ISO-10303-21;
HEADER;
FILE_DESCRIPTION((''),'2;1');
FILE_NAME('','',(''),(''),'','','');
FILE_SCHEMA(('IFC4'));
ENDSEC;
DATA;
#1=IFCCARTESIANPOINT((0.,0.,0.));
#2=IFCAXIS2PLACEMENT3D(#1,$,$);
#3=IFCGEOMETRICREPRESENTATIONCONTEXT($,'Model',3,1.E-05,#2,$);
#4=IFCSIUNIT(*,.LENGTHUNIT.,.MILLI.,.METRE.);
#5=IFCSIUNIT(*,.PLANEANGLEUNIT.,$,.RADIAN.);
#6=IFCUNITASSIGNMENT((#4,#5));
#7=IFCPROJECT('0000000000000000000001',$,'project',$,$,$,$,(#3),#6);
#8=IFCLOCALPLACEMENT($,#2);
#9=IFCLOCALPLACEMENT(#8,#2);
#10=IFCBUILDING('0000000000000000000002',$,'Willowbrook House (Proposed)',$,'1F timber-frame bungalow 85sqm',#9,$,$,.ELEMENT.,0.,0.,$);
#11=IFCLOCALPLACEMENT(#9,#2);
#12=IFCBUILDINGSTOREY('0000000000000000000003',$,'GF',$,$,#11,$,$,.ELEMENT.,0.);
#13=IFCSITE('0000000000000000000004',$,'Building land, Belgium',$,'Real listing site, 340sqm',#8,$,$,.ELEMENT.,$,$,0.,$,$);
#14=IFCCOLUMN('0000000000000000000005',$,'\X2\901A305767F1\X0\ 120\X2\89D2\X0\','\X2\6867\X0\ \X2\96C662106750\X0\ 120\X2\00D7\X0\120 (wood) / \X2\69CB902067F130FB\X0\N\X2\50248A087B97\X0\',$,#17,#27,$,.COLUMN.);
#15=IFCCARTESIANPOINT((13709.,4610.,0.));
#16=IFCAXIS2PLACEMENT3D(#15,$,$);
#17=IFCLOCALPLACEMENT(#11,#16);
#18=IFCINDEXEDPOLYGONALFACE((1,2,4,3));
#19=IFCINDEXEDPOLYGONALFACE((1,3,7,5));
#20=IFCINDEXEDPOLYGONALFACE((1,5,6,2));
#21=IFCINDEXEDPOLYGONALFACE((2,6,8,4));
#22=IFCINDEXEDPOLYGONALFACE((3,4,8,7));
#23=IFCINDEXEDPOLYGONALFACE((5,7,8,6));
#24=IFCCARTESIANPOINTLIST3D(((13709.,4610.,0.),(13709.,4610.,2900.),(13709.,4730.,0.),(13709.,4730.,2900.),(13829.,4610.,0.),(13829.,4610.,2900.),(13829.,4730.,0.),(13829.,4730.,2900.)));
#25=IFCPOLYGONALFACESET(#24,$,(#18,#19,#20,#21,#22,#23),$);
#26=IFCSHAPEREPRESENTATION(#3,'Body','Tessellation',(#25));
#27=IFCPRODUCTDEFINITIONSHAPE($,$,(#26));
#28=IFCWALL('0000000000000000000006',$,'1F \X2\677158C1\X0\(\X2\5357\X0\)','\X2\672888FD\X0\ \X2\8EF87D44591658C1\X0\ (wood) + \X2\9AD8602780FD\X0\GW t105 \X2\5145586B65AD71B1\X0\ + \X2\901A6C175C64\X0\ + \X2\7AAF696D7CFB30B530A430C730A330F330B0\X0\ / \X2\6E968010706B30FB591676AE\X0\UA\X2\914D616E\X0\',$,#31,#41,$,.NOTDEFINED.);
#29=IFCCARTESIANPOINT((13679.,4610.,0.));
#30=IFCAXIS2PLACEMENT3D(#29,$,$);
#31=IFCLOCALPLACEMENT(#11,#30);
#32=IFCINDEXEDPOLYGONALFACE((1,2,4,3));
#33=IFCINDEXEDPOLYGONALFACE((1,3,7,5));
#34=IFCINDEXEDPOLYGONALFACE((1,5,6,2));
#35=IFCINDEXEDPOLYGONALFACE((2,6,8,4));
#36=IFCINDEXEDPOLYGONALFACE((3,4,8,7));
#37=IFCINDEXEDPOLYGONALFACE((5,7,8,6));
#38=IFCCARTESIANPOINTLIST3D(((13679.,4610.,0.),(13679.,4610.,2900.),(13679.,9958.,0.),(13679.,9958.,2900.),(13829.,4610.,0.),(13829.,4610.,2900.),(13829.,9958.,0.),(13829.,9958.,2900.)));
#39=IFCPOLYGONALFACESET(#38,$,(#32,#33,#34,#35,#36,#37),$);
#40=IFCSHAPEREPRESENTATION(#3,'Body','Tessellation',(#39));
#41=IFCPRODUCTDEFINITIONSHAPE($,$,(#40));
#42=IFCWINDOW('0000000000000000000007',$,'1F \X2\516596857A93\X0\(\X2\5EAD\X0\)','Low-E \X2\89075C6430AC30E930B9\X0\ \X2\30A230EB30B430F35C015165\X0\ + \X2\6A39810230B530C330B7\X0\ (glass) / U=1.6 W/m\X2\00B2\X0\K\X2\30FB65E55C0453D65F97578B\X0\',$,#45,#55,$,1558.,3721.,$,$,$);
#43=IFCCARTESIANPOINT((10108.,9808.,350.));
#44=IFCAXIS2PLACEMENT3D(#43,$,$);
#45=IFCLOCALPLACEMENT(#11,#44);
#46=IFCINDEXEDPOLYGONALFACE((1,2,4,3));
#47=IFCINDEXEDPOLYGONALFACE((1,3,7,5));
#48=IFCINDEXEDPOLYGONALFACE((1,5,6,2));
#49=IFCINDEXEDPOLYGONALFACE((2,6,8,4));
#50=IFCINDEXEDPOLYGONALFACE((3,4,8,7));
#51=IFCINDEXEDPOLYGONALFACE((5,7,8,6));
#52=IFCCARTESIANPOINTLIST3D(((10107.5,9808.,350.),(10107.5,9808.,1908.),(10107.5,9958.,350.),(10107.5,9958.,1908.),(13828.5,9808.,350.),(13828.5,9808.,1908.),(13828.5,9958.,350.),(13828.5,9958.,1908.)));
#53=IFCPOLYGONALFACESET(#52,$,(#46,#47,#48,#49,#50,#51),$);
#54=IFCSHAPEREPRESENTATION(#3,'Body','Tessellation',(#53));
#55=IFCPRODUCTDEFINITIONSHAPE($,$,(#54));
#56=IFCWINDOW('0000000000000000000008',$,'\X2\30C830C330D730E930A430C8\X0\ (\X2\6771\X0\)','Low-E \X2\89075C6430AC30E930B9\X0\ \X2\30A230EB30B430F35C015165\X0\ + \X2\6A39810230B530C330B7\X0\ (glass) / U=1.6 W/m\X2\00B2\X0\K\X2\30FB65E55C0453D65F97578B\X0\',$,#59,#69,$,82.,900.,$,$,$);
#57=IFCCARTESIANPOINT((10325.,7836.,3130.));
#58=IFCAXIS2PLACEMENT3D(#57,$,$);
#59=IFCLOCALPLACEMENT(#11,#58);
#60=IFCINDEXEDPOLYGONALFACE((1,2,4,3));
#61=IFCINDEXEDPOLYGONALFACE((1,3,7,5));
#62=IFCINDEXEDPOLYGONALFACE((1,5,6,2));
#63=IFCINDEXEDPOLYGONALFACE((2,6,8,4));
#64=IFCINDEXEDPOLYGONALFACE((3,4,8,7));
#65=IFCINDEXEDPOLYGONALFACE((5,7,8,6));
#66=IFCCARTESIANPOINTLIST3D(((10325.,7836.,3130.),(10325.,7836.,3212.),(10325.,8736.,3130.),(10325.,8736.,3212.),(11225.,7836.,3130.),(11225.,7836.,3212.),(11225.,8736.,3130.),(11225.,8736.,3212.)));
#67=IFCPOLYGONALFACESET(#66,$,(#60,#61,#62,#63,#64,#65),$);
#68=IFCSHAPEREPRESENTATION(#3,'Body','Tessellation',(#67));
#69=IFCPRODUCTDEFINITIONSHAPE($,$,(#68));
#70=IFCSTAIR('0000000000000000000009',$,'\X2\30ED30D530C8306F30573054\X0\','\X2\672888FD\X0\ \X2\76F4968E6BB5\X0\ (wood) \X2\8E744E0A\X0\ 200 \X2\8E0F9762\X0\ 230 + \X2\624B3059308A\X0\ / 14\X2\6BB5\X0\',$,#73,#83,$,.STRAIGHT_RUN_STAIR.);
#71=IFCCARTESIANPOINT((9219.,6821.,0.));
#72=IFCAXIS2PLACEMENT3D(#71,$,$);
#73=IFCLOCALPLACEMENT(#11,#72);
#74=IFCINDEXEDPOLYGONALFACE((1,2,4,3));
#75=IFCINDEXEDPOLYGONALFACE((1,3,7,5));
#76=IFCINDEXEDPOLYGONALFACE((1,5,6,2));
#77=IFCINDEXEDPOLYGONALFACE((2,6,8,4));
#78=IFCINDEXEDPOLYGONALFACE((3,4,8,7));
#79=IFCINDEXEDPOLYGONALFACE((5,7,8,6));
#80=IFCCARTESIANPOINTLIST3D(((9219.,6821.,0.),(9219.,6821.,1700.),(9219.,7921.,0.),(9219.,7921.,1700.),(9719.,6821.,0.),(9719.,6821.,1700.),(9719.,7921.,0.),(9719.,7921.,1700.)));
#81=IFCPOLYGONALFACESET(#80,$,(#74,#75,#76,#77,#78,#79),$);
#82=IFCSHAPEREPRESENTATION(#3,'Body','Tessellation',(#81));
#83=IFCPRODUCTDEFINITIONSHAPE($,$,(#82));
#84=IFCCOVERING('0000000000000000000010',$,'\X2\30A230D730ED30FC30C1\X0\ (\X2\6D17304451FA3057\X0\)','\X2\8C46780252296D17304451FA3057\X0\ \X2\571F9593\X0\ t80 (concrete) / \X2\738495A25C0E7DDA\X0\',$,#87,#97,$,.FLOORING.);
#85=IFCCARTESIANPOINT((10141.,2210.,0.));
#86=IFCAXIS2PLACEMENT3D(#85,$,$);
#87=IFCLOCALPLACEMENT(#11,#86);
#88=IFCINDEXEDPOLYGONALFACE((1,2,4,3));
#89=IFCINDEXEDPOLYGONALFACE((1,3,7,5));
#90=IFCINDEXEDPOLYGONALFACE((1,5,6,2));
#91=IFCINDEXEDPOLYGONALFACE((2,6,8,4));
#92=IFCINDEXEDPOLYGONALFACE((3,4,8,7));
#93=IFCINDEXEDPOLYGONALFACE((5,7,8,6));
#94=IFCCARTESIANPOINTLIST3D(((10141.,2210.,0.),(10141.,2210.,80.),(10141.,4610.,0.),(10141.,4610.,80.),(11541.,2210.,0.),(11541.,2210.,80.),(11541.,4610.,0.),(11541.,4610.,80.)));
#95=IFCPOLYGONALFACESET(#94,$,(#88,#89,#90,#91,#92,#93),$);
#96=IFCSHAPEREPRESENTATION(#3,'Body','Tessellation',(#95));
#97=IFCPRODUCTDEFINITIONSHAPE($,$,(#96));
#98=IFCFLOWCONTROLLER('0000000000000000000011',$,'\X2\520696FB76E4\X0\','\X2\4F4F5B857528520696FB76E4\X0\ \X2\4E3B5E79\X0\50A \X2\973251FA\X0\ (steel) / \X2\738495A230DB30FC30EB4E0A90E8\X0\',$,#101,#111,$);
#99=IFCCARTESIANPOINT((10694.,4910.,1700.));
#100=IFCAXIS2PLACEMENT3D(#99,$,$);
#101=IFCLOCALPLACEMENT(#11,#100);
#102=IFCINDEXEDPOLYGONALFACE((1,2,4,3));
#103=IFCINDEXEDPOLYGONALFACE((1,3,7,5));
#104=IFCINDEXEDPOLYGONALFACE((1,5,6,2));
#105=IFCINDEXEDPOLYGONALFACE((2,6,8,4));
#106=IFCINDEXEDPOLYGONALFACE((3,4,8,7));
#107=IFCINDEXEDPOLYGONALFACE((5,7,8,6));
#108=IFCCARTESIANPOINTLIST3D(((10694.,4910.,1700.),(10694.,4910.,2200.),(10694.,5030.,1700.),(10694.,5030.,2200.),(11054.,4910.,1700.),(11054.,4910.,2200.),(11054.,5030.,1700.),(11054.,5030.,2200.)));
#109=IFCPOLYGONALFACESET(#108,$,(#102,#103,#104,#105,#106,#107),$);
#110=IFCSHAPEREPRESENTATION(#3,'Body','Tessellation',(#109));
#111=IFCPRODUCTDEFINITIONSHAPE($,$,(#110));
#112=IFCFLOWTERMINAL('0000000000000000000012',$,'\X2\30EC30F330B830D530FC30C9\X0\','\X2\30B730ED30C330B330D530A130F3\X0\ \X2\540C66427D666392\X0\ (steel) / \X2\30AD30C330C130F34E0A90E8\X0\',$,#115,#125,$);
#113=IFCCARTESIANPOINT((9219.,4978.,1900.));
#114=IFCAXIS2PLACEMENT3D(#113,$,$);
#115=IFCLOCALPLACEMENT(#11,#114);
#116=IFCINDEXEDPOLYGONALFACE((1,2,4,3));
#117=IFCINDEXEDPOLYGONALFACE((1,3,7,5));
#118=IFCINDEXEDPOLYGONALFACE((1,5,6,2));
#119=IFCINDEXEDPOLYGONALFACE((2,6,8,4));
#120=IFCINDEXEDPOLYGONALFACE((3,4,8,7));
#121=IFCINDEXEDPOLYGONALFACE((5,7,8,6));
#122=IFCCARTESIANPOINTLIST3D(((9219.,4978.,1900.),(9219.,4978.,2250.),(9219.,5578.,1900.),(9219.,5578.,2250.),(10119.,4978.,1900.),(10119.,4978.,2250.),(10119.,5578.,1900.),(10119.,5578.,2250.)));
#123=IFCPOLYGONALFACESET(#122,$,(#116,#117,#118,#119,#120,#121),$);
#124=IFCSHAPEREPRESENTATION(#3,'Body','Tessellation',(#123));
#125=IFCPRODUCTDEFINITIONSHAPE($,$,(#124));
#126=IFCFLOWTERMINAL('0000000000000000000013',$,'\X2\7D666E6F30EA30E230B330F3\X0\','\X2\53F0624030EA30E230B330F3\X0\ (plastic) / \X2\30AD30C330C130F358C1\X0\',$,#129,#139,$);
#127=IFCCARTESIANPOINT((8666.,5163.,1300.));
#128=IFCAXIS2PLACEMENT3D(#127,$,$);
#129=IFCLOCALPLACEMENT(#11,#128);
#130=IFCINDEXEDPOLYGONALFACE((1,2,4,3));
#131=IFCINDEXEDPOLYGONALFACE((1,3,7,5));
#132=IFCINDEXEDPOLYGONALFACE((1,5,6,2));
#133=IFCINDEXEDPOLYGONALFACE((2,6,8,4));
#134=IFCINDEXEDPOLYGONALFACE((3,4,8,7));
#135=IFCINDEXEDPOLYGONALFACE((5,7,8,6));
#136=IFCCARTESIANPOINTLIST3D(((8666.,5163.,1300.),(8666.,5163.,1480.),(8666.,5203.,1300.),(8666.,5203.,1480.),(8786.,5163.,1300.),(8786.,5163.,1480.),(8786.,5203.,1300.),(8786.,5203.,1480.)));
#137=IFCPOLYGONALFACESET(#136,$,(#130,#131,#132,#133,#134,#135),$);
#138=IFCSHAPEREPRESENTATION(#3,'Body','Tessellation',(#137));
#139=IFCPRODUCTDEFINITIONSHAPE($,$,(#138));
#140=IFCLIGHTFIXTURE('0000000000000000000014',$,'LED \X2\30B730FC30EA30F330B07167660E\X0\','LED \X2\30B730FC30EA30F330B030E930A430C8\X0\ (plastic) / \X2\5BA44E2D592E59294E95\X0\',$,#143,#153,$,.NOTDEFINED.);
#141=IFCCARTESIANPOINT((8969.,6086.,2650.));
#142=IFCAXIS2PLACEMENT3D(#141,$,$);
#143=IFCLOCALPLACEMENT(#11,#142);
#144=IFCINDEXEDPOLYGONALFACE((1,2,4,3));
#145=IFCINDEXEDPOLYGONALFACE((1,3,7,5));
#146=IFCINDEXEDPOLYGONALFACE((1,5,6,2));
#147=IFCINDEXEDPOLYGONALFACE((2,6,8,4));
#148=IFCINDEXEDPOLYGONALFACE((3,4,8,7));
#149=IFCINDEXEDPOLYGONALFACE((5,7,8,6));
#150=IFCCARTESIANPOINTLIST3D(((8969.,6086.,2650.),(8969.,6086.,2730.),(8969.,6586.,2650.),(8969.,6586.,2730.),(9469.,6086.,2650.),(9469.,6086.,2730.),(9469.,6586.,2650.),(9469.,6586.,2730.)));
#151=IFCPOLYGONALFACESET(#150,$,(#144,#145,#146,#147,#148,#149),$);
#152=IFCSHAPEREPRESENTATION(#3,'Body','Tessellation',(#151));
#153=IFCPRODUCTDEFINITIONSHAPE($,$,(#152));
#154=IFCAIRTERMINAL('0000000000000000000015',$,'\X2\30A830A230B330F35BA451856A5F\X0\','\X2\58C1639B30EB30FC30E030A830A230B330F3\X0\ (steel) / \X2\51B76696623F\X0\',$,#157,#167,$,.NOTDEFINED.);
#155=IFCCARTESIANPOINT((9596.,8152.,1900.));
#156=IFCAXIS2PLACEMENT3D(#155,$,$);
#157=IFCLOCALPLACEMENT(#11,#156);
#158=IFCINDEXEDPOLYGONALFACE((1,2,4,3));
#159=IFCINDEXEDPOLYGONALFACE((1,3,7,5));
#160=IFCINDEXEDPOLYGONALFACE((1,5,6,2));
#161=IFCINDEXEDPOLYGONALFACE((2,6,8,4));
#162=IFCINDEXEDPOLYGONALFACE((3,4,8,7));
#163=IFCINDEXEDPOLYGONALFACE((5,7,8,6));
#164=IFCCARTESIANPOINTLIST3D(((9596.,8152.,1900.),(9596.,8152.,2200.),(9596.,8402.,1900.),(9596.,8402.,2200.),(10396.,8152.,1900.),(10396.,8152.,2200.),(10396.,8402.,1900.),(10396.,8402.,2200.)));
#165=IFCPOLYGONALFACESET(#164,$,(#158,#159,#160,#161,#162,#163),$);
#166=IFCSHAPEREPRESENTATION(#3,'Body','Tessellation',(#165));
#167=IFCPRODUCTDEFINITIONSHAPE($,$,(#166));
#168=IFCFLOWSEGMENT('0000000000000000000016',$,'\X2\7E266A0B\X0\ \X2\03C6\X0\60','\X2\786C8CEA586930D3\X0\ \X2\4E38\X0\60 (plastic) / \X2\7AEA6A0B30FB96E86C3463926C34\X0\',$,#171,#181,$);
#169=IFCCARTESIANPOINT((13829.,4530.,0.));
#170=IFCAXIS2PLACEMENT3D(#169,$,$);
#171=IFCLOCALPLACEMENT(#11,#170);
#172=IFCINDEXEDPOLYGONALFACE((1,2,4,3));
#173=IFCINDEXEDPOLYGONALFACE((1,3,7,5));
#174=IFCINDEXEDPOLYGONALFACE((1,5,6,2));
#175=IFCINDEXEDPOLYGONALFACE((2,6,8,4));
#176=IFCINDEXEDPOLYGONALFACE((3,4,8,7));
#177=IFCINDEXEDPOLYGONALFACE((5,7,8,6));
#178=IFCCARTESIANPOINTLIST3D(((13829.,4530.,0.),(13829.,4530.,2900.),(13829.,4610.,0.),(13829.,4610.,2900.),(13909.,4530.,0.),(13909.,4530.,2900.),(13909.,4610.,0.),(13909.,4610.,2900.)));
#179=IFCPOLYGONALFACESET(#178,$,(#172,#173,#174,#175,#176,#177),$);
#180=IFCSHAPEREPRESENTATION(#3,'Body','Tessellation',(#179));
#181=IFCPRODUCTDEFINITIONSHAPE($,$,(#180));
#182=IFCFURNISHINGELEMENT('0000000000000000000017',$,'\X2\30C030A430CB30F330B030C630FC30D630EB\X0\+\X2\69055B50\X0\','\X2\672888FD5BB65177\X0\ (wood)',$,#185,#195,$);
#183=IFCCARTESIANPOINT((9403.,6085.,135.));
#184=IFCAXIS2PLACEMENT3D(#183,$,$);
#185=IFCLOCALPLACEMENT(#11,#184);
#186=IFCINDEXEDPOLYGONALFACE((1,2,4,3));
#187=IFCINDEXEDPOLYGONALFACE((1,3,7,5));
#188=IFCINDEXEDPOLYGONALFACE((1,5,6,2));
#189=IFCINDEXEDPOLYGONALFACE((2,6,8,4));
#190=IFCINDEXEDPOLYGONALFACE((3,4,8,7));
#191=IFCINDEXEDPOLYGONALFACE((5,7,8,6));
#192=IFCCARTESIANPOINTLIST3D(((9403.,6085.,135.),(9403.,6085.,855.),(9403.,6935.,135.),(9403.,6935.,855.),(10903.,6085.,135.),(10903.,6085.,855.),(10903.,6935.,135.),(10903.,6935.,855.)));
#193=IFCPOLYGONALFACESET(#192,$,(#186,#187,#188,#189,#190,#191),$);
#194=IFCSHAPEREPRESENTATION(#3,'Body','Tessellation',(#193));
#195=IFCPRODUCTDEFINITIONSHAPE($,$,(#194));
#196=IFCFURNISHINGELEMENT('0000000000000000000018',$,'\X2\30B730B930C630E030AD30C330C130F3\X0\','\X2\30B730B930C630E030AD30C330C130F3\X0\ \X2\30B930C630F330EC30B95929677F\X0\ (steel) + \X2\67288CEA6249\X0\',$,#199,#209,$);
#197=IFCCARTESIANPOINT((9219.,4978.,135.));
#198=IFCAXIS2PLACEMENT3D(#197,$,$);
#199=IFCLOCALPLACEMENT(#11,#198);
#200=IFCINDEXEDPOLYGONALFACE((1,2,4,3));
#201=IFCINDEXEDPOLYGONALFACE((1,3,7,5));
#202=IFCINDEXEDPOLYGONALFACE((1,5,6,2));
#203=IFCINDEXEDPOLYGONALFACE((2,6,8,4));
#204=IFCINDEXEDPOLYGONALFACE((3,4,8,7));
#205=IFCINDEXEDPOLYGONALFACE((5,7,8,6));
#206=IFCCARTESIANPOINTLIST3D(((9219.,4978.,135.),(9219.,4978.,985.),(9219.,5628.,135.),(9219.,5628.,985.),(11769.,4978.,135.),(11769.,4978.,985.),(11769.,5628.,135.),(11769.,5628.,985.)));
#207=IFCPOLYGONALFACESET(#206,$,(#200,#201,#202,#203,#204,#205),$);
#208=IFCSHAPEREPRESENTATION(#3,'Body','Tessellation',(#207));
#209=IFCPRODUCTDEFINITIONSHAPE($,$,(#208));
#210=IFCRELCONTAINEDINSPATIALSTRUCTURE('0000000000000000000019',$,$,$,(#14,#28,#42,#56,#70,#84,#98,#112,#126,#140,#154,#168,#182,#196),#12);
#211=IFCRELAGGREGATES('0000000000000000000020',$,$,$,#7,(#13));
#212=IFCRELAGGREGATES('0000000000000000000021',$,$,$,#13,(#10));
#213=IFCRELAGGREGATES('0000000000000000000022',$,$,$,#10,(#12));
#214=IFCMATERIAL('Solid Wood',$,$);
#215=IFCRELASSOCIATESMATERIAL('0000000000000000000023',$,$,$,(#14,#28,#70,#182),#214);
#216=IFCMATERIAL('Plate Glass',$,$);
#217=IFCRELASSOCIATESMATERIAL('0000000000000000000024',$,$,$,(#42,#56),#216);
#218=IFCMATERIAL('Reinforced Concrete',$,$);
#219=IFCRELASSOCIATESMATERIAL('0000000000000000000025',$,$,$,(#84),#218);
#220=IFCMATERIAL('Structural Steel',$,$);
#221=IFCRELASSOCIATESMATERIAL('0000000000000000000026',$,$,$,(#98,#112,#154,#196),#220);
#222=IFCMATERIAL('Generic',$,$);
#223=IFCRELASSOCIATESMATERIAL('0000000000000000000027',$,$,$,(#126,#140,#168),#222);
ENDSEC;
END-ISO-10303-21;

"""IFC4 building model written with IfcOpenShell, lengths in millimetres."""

from ifc_helpers import new_model, si_unit, frame, frame_2d, origin, place, context, project, spatial, rectangle, extrude, material, element, fill, save


model = new_model("IFC4")

# Units and contexts
model_context = context("Model", 3, precision=1e-05, world=origin())
ifc_project = project(units=[si_unit("LENGTHUNIT", "METRE", prefix="MILLI"), si_unit("PLANEANGLEUNIT", "RADIAN")], contexts=[model_context])

# Site, building, storey
site_placement = place(None, origin())
site = spatial("IfcSite", under=ifc_project, at=site_placement, Name="Building land, Belgium", ObjectType="Real listing site, 340sqm", CompositionType="ELEMENT", RefElevation=0.0)
building_placement = place(site_placement, origin())
building = spatial("IfcBuilding", under=site, at=building_placement, Name="Willowbrook House (Proposed)", ObjectType="1F timber-frame bungalow 85sqm", CompositionType="ELEMENT", ElevationOfRefHeight=0.0, ElevationOfTerrain=0.0)
storey_placement = place(building_placement, origin())
storey = spatial("IfcBuildingStorey", under=building, at=storey_placement, Name="GF", CompositionType="ELEMENT", Elevation=0.0)

# Column
ifc_material_1 = material(Name="Solid Wood")
column_1_placement = place(storey_placement, frame((13709.0, 4610.0, 0.0)))
element("IfcColumn", 1, at=column_1_placement, inside=storey, material=ifc_material_1, Name="通し柱 120角", Description="桧 集成材 120×120 (wood) / 構造柱・N値計算", PredefinedType="COLUMN", context=model_context, shape_type="SweptSolid", body=[
    extrude(rectangle(XDim=120.0, YDim=120.0, at=frame_2d((60.0, 60.0))), frame((13709.0, 4610.0, 0.0)), (0.0, 0.0, 1.0), 2900.0),
])

# Wall, opening, window
wall_1_placement = place(storey_placement, frame((13679.0, 4610.0, 0.0)))
wall_1 = element("IfcWall", 2, at=wall_1_placement, inside=storey, material=ifc_material_1, Name="1F 東壁(南)", Description="木製 軸組外壁 (wood) + 高性能GW t105 充填断熱 + 通気層 + 窯業系サイディング / 準耐火・外皮UA配慮", PredefinedType="NOTDEFINED", context=model_context, shape_type="SweptSolid", body=[
    extrude(rectangle(XDim=150.0, YDim=5348.0, at=frame_2d((75.0, 2674.0))), frame((13679.0, 4610.0, 0.0)), (0.0, 0.0, 1.0), 2900.0),
])
opening_placement = place(storey_placement, frame((10108.0, 9808.0, 350.0)))
opening = element("IfcOpeningElement", 3, at=opening_placement, cuts=wall_1, PredefinedType="NOTDEFINED", context=model_context, shape_type="SweptSolid", body=[
    extrude(rectangle(XDim=3721.0, YDim=150.0, at=frame_2d((1860.0, 75.0))), frame((10108.0, 9808.0, 350.0)), (0.0, 0.0, 1.0), 1558.0),
])
ifc_material_2 = material(Name="Plate Glass")
window_1_placement = place(storey_placement, frame((10108.0, 9808.0, 350.0)))
window_1 = element("IfcWindow", 4, at=window_1_placement, inside=storey, material=ifc_material_2, Name="1F 入隅窓(庭)", Description="Low-E 複層ガラス アルゴン封入 + 樹脂サッシ (glass) / U=1.6 W/m²K・日射取得型", OverallHeight=1558.0, OverallWidth=3721.0, context=model_context, shape_type="SweptSolid", body=[
    extrude(rectangle(XDim=3721.0, YDim=150.0, at=frame_2d((1860.0, 75.0))), frame((10108.0, 9808.0, 350.0)), (0.0, 0.0, 1.0), 1558.0),
])
fill(opening, window_1)

# Window
window_2_placement = place(storey_placement, frame((10325.0, 7836.0, 3130.0)))
element("IfcWindow", 5, at=window_2_placement, inside=storey, material=ifc_material_2, Name="トップライト (東)", Description="Low-E 複層ガラス アルゴン封入 + 樹脂サッシ (glass) / U=1.6 W/m²K・日射取得型", OverallHeight=82.0, OverallWidth=900.0, context=model_context, shape_type="SweptSolid", body=[
    extrude(rectangle(XDim=900.0, YDim=900.0, at=frame_2d((450.0, 450.0))), frame((10325.0, 7836.0, 3130.0)), (0.0, 0.0, 1.0), 82.0),
])

# Stair
stair_placement = place(storey_placement, frame((9219.0, 6821.0, 0.0)))
element("IfcStair", 6, at=stair_placement, inside=storey, material=ifc_material_1, Name="ロフトはしご", Description="木製 直階段 (wood) 蹴上 200 踏面 230 + 手すり / 14段", PredefinedType="STRAIGHT_RUN_STAIR", context=model_context, shape_type="SweptSolid", body=[
    extrude(rectangle(XDim=500.0, YDim=1100.0, at=frame_2d((250.0, 550.0))), frame((9219.0, 6821.0, 0.0)), (0.0, 0.0, 1.0), 1700.0),
])

# Covering
ifc_material_3 = material(Name="Reinforced Concrete")
covering_placement = place(storey_placement, frame((10141.0, 2210.0, 0.0)))
element("IfcCovering", 7, at=covering_placement, inside=storey, material=ifc_material_3, Name="アプローチ (洗い出し)", Description="豆砂利洗い出し 土間 t80 (concrete) / 玄関導線", PredefinedType="FLOORING", context=model_context, shape_type="SweptSolid", body=[
    extrude(rectangle(XDim=1400.0, YDim=2400.0, at=frame_2d((700.0, 1200.0))), frame((10141.0, 2210.0, 0.0)), (0.0, 0.0, 1.0), 80.0),
])

# Flow controller
ifc_material_4 = material(Name="Structural Steel")
flow_controller_placement = place(storey_placement, frame((10694.0, 4910.0, 1700.0)))
element("IfcFlowController", 8, at=flow_controller_placement, inside=storey, material=ifc_material_4, Name="分電盤", Description="住宅用分電盤 主幹50A 露出 (steel) / 玄関ホール上部", context=model_context, shape_type="SweptSolid", body=[
    extrude(rectangle(XDim=360.0, YDim=120.0, at=frame_2d((180.0, 60.0))), frame((10694.0, 4910.0, 1700.0)), (0.0, 0.0, 1.0), 500.0),
])

# Flow terminals
flow_terminal_1_placement = place(storey_placement, frame((9219.0, 4978.0, 1900.0)))
element("IfcFlowTerminal", 9, at=flow_terminal_1_placement, inside=storey, material=ifc_material_4, Name="レンジフード", Description="シロッコファン 同時給排 (steel) / キッチン上部", context=model_context, shape_type="SweptSolid", body=[
    extrude(rectangle(XDim=900.0, YDim=600.0, at=frame_2d((450.0, 300.0))), frame((9219.0, 4978.0, 1900.0)), (0.0, 0.0, 1.0), 350.0),
])
ifc_material_5 = material(Name="Generic")
flow_terminal_2_placement = place(storey_placement, frame((8666.0, 5163.0, 1300.0)))
element("IfcFlowTerminal", 10, at=flow_terminal_2_placement, inside=storey, material=ifc_material_5, Name="給湯リモコン", Description="台所リモコン (plastic) / キッチン壁", context=model_context, shape_type="SweptSolid", body=[
    extrude(rectangle(XDim=120.0, YDim=40.0, at=frame_2d((60.0, 20.0))), frame((8666.0, 5163.0, 1300.0)), (0.0, 0.0, 1.0), 180.0),
])

# Light fixture
light_fixture_placement = place(storey_placement, frame((8969.0, 6086.0, 2650.0)))
element("IfcLightFixture", 11, at=light_fixture_placement, inside=storey, material=ifc_material_5, Name="LED シーリング照明", Description="LED シーリングライト (plastic) / 室中央天井", PredefinedType="NOTDEFINED", context=model_context, shape_type="SweptSolid", body=[
    extrude(rectangle(XDim=500.0, YDim=500.0, at=frame_2d((250.0, 250.0))), frame((8969.0, 6086.0, 2650.0)), (0.0, 0.0, 1.0), 80.0),
])

# Air terminal
air_terminal_placement = place(storey_placement, frame((9596.0, 8152.0, 1900.0)))
element("IfcAirTerminal", 12, at=air_terminal_placement, inside=storey, material=ifc_material_4, Name="エアコン室内機", Description="壁掛ルームエアコン (steel) / 冷暖房", PredefinedType="NOTDEFINED", context=model_context, shape_type="SweptSolid", body=[
    extrude(rectangle(XDim=800.0, YDim=250.0, at=frame_2d((400.0, 125.0))), frame((9596.0, 8152.0, 1900.0)), (0.0, 0.0, 1.0), 300.0),
])

# Flow segment
flow_segment_placement = place(storey_placement, frame((13829.0, 4530.0, 0.0)))
element("IfcFlowSegment", 13, at=flow_segment_placement, inside=storey, material=ifc_material_5, Name="縦樋 φ60", Description="硬質塩ビ 丸60 (plastic) / 竪樋・雨水排水", context=model_context, shape_type="SweptSolid", body=[
    extrude(rectangle(XDim=80.0, YDim=80.0, at=frame_2d((40.0, 40.0))), frame((13829.0, 4530.0, 0.0)), (0.0, 0.0, 1.0), 2900.0),
])

# Furnishing elements
furnishing_1_placement = place(storey_placement, frame((9403.0, 6085.0, 135.0)))
element("IfcFurnishingElement", 14, at=furnishing_1_placement, inside=storey, material=ifc_material_1, Name="ダイニングテーブル+椅子", Description="木製家具 (wood)", context=model_context, shape_type="SweptSolid", body=[
    extrude(rectangle(XDim=1500.0, YDim=850.0, at=frame_2d((750.0, 425.0))), frame((9403.0, 6085.0, 135.0)), (0.0, 0.0, 1.0), 720.0),
])
furnishing_2_placement = place(storey_placement, frame((9219.0, 4978.0, 135.0)))
element("IfcFurnishingElement", 15, at=furnishing_2_placement, inside=storey, material=ifc_material_4, Name="システムキッチン", Description="システムキッチン ステンレス天板 (steel) + 木質扉", context=model_context, shape_type="SweptSolid", body=[
    extrude(rectangle(XDim=2550.0, YDim=650.0, at=frame_2d((1275.0, 325.0))), frame((9219.0, 4978.0, 135.0)), (0.0, 0.0, 1.0), 850.0),
])

save(model, "model.ifc")
